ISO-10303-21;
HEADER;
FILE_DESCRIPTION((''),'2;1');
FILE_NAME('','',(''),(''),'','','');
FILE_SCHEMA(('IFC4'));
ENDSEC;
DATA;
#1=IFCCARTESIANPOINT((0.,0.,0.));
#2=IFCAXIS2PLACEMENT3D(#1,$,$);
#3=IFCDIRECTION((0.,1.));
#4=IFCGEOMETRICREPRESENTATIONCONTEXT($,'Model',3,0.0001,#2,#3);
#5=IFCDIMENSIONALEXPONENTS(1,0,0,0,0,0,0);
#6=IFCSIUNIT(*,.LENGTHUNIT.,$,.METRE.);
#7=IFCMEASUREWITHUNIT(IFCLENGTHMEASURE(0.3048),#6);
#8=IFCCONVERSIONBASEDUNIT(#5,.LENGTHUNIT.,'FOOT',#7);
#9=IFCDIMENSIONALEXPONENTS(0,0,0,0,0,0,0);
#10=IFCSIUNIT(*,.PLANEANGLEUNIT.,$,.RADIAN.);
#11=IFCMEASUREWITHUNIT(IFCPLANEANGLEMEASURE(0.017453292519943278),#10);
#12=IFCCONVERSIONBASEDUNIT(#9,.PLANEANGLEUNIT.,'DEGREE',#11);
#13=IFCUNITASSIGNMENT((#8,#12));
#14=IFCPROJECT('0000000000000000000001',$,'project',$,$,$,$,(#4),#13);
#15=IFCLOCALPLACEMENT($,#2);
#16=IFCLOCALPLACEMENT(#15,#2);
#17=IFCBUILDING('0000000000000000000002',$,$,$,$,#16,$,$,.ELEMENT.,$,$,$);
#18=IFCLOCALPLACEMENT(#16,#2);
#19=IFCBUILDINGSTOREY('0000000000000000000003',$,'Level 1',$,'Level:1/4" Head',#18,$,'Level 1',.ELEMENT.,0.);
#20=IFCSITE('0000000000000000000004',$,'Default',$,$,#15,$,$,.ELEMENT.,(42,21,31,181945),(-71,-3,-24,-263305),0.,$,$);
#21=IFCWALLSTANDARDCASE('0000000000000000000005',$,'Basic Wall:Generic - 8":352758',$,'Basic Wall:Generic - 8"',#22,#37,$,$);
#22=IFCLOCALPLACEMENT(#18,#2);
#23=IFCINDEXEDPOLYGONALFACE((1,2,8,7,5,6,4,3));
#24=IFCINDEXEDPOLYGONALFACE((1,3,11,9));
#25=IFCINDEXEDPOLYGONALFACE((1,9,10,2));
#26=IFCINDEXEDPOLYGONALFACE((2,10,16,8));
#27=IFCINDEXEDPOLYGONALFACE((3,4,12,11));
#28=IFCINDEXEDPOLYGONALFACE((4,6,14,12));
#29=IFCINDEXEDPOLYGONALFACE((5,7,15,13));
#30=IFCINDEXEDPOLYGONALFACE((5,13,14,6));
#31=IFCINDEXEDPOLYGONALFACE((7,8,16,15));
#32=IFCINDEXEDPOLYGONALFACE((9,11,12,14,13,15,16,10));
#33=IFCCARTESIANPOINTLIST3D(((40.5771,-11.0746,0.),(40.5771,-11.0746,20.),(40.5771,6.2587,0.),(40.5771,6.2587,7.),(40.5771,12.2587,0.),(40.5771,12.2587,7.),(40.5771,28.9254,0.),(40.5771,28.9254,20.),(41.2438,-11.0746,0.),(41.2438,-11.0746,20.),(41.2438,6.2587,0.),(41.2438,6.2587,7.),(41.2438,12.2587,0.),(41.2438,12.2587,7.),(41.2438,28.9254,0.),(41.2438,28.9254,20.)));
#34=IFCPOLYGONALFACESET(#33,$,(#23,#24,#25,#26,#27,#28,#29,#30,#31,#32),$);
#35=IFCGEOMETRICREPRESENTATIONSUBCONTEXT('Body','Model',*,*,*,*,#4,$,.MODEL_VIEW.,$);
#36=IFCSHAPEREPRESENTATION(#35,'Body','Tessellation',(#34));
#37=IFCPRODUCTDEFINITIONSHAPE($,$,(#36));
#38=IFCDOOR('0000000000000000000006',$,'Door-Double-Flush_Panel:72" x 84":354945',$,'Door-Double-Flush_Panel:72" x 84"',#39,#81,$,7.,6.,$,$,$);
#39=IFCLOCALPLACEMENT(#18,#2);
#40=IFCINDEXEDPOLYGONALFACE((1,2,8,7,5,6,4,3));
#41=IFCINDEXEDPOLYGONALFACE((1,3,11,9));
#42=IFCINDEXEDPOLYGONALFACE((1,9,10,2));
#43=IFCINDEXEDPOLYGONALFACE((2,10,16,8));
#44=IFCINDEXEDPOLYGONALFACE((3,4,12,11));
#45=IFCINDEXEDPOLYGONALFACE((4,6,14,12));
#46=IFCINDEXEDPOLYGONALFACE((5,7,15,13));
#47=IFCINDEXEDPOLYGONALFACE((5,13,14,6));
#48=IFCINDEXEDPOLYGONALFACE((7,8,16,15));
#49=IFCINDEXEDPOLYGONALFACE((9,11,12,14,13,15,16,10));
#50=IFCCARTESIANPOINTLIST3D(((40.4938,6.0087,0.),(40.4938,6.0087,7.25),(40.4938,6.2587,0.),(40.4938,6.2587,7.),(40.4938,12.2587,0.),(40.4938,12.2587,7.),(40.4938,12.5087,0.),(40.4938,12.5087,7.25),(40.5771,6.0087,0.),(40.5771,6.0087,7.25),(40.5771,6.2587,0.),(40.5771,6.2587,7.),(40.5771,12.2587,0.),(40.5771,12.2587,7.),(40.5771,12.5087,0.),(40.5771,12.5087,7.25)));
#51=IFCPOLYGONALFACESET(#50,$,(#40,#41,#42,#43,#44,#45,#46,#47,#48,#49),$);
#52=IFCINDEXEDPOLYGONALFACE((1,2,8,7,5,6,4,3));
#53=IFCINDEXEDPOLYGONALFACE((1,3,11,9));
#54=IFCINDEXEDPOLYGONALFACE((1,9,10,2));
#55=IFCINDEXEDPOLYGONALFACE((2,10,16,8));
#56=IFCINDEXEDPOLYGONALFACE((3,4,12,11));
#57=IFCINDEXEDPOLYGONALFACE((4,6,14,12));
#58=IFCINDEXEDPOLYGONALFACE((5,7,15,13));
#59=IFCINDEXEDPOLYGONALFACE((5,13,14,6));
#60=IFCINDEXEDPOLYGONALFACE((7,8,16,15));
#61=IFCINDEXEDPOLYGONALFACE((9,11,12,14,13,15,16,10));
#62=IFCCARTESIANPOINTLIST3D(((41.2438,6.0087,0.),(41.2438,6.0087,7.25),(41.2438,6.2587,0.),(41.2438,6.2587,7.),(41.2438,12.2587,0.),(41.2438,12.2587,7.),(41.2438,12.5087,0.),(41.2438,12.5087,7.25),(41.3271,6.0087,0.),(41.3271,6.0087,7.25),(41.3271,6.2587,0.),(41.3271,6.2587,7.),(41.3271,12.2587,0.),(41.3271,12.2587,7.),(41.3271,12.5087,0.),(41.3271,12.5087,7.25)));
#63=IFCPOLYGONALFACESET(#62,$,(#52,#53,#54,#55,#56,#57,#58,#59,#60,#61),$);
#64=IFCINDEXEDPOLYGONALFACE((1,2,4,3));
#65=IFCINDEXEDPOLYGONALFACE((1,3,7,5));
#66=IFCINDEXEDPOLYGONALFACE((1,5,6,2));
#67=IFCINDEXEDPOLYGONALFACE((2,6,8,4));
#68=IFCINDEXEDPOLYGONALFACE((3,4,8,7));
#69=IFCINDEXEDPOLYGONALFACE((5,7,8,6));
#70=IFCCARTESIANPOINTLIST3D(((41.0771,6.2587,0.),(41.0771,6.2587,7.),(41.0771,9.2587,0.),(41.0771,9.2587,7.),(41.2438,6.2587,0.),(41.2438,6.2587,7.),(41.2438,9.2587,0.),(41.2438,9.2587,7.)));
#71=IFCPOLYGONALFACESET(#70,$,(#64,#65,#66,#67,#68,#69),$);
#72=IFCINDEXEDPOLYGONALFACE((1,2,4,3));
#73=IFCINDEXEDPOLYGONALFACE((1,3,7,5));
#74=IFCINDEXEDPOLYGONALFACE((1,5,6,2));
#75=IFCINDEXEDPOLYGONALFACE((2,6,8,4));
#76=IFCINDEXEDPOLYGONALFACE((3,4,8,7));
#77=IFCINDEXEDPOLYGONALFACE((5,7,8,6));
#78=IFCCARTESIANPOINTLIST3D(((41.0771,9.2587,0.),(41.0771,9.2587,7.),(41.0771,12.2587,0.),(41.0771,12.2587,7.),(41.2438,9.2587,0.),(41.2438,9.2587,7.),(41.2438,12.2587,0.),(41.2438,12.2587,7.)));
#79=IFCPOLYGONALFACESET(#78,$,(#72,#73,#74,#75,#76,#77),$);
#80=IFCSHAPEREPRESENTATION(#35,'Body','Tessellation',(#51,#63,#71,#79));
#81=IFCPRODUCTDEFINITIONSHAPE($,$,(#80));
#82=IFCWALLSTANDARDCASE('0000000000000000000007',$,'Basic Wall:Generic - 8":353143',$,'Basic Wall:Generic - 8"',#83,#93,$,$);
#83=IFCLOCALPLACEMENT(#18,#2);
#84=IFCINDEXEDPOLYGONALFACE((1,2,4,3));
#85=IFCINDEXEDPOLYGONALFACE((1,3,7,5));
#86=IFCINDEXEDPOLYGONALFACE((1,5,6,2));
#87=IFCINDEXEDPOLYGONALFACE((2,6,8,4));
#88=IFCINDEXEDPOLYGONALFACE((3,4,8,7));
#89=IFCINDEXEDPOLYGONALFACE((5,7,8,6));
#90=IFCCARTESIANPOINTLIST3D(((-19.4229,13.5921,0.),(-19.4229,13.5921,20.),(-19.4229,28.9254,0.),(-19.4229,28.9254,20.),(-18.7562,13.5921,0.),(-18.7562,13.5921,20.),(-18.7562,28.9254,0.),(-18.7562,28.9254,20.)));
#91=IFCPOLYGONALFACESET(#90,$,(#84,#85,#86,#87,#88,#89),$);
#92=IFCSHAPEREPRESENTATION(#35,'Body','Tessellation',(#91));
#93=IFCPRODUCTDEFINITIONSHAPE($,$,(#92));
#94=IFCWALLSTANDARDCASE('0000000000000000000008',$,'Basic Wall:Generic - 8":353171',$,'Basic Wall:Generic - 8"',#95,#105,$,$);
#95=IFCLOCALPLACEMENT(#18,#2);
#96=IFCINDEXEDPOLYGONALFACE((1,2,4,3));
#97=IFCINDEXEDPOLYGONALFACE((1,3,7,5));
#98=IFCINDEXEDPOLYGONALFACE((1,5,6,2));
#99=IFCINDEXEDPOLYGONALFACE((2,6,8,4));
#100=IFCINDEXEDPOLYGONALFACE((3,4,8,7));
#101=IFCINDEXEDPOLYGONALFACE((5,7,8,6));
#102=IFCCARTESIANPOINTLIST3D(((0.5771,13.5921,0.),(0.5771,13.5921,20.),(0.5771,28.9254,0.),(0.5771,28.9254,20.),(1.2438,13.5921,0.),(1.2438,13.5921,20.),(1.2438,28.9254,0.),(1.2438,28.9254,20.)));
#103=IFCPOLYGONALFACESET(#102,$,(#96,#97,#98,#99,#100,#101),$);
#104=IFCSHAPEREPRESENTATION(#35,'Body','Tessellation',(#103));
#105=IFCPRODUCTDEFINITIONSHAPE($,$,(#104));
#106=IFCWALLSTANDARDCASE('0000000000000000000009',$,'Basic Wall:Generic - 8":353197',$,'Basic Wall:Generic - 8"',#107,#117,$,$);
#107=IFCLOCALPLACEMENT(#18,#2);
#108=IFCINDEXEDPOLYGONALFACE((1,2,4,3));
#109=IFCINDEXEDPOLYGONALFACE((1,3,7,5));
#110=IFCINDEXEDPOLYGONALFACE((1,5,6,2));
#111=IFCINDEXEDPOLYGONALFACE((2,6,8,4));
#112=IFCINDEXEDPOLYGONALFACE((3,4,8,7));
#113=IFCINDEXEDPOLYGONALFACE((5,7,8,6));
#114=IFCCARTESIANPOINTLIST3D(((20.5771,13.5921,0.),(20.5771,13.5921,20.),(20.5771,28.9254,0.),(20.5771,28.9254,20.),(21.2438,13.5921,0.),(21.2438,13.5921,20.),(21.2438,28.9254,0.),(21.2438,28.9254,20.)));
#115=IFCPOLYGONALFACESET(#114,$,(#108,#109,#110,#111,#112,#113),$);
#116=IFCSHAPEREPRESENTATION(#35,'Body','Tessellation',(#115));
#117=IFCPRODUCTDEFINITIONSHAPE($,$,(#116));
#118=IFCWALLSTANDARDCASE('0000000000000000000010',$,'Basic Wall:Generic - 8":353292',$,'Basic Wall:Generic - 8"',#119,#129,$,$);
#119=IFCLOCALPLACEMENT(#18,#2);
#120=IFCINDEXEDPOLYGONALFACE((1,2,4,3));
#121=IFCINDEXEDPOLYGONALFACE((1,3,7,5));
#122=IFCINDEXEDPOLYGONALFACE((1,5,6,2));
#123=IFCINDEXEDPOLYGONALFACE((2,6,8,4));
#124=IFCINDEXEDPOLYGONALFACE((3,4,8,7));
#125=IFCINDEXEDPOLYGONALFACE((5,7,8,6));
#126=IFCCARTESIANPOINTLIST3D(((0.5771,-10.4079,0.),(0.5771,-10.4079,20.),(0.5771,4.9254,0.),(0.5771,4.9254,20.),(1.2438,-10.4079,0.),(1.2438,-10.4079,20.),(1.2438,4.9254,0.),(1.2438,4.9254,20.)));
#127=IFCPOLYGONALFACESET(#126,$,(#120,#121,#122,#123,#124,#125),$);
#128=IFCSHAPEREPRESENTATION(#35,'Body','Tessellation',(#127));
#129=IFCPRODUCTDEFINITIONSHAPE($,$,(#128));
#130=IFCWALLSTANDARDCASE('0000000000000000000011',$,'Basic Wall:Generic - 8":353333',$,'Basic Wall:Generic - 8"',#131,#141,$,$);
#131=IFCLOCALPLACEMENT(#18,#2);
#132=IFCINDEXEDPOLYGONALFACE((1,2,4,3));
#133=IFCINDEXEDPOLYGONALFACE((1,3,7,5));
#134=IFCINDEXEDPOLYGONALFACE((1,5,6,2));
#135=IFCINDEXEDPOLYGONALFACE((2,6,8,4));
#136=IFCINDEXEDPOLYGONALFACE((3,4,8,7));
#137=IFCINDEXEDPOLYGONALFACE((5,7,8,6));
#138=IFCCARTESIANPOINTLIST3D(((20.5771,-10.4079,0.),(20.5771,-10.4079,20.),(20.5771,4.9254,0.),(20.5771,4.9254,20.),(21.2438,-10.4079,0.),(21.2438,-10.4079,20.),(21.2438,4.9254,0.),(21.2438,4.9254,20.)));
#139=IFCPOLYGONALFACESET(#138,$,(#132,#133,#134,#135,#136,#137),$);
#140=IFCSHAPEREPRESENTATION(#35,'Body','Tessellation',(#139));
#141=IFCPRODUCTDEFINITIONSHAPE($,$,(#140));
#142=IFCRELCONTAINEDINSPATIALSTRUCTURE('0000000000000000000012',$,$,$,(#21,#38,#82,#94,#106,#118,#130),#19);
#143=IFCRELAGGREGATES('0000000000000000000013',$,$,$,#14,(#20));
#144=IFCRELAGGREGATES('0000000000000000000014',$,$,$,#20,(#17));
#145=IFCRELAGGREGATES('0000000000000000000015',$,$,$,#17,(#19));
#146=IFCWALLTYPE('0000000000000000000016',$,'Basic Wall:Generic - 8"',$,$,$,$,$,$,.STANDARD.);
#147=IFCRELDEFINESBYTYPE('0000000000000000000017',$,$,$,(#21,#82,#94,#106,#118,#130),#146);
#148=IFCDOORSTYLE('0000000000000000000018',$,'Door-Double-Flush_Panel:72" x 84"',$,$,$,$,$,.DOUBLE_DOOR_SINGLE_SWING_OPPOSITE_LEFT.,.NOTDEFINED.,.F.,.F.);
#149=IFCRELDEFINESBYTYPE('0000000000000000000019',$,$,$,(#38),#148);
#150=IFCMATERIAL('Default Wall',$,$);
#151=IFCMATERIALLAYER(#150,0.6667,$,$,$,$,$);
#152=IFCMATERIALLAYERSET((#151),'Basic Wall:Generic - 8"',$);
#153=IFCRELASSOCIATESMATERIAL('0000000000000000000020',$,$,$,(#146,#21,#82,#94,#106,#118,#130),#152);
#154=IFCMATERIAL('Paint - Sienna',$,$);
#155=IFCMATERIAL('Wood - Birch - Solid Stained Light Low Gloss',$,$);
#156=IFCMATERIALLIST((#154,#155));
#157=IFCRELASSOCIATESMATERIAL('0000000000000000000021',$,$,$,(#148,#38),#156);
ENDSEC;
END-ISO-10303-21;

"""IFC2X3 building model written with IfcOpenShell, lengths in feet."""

from ifc_helpers import new_model, entity, si_unit, converted_unit, direction, frame, frame_2d, origin, place, context, subcontext, project, spatial, polyline, rectangle, outline, extrude, source, transform, mapped, material, material_list, layer, layer_set, layer_usage, type_object, type_shapes, element, fill, save


model = new_model("IFC2X3")

# Units and contexts
model_context = context("Model", 3, precision=0.0001, world=origin(), true_north=direction((0.0, 1.0)))
body_context = subcontext(model_context, "Body", "Model", "MODEL_VIEW")
ifc_project = project(units=[converted_unit("LENGTHUNIT", "FOOT", entity("IfcLengthMeasure", 0.3048), si_unit("LENGTHUNIT", "METRE"), dimensions=[1, 0, 0, 0, 0, 0, 0]), converted_unit("PLANEANGLEUNIT", "DEGREE", entity("IfcPlaneAngleMeasure", 0.017453292519943278), si_unit("PLANEANGLEUNIT", "RADIAN"), dimensions=[0, 0, 0, 0, 0, 0, 0])], contexts=[model_context])

# Site, building, storey
site_placement = place(None, origin())
site = spatial("IfcSite", under=ifc_project, at=site_placement, Name="Default", CompositionType="ELEMENT", RefLatitude=(42, 21, 31, 181945), RefLongitude=(-71, -3, -24, -263305), RefElevation=0.0)
building_placement = place(site_placement, origin())
building = spatial("IfcBuilding", under=site, at=building_placement, CompositionType="ELEMENT")
storey_placement = place(building_placement, origin())
storey = spatial("IfcBuildingStorey", under=building, at=storey_placement, Name="Level 1", ObjectType="Level:1/4\" Head", LongName="Level 1", CompositionType="ELEMENT", Elevation=0.0)

# Wall, opening, door
ifc_material_1 = material(Name="Default Wall")
ifc_layer = layer(ifc_material_1, 0.6667)
ifc_layer_set = layer_set([ifc_layer], Name="Basic Wall:Generic - 8\"")
ifc_layer_usage = layer_usage(ifc_layer_set, "AXIS2", "NEGATIVE", 0.3333)
wall_type = type_object("IfcWallType", Name="Basic Wall:Generic - 8\"", PredefinedType="STANDARD", material=ifc_layer_set)
wall_1_placement = place(storey_placement, frame((40.9105, 28.9254, 0.0), z_axis=(0.0, 0.0, 1.0), x_axis=(0.0, -1.0, 0.0)))
wall_1 = element("IfcWallStandardCase", 1, at=wall_1_placement, inside=storey, type_object=wall_type, material=ifc_layer_usage, Name="Basic Wall:Generic - 8\":352758", ObjectType="Basic Wall:Generic - 8\"", context=body_context, shape_type="SweptSolid", body=[
    extrude(rectangle(XDim=40.0, YDim=0.6667, at=frame_2d((20.0, 0.0), x_axis=(-1.0, 0.0))), origin(), (0.0, 0.0, 1.0), 20.0),
])
opening_1_placement = place(wall_1_placement, frame((16.6667, -0.3333, 0.0)))
opening_1 = element("IfcOpeningElement", 2, at=opening_1_placement, cuts=wall_1, ObjectType="Opening", context=body_context, shape_type="SweptSolid", body=[
    extrude(rectangle(XDim=7.0, YDim=6.0, at=frame_2d((3.5, 3.0), x_axis=(1.0, 0.0))), frame((0.0, 0.0, 0.0), z_axis=(0.0, 1.0, 0.0), x_axis=(0.0, 0.0, 1.0)), (0.0, 0.0, 1.0), 0.6667),
])
ifc_material_2 = material(Name="Paint - Sienna")
ifc_material_3 = material(Name="Wood - Birch - Solid Stained Light Low Gloss")
ifc_material_list_1 = material_list([ifc_material_2, ifc_material_3])
door_style = type_object("IfcDoorStyle", Name="Door-Double-Flush_Panel:72\" x 84\"", ConstructionType="NOTDEFINED", OperationType="DOUBLE_DOOR_SINGLE_SWING_OPPOSITE_LEFT", ParameterTakesPrecedence=False, Sizeable=False, material=ifc_material_list_1)
shared_shape_1 = source(origin(), body_context, "Body", "SweptSolid", [
    extrude(outline(polyline([(-3.4375, 3.0), (3.5625, 3.0), (3.5625, 3.25), (-3.6875, 3.25), (-3.6875, -3.25), (3.5625, -3.25), (3.5625, -3.0), (-3.4375, -3.0), (-3.4375, 3.0)])), frame((3.0, -0.0833, 3.5625), z_axis=(0.0, 1.0, 0.0), x_axis=(0.0, 0.0, -1.0)), (0.0, 0.0, 1.0), 0.0833),
    extrude(outline(polyline([(-3.4375, 3.0), (3.5625, 3.0), (3.5625, 3.25), (-3.6875, 3.25), (-3.6875, -3.25), (3.5625, -3.25), (3.5625, -3.0), (-3.4375, -3.0), (-3.4375, 3.0)])), frame((3.0, 0.6667, 3.5625), z_axis=(0.0, 1.0, 0.0), x_axis=(0.0, 0.0, -1.0)), (0.0, 0.0, 1.0), 0.0833),
    extrude(rectangle(XDim=0.1667, YDim=3.0, at=frame_2d((0.0, 0.0), x_axis=(1.0, 0.0))), frame((4.5, 0.5833, 0.0), z_axis=(0.0, 0.0, 1.0), x_axis=(0.0, -1.0, 0.0)), (0.0, 0.0, 1.0), 7.0),
    extrude(rectangle(XDim=0.1667, YDim=3.0, at=frame_2d((0.0, 0.0), x_axis=(1.0, 0.0))), frame((1.5, 0.5833, 0.0), z_axis=(0.0, 0.0, 1.0), x_axis=(0.0, -1.0, 0.0)), (0.0, 0.0, 1.0), 7.0),
])
type_shapes(door_style, [shared_shape_1])
door_placement = place(opening_1_placement, origin())
door = element("IfcDoor", 3, at=door_placement, inside=storey, type_object=door_style, material=ifc_material_list_1, Name="Door-Double-Flush_Panel:72\" x 84\":354945", ObjectType="Door-Double-Flush_Panel:72\" x 84\"", OverallHeight=7.0, OverallWidth=6.0, context=body_context, shape_type="MappedRepresentation", body=[
    mapped(shared_shape_1, transform((0.0, 0.0, 0.0), scale=1.0)),
])
fill(opening_1, door)

# Walls
wall_2_placement = place(storey_placement, frame((-19.0895, 28.9254, 0.0), z_axis=(0.0, 0.0, 1.0), x_axis=(0.0, -1.0, 0.0)))
element("IfcWallStandardCase", 4, at=wall_2_placement, inside=storey, type_object=wall_type, material=ifc_layer_usage, Name="Basic Wall:Generic - 8\":353143", ObjectType="Basic Wall:Generic - 8\"", context=body_context, shape_type="SweptSolid", body=[
    extrude(rectangle(XDim=15.3333, YDim=0.6667, at=frame_2d((7.6667, 0.0), x_axis=(-1.0, 0.0))), origin(), (0.0, 0.0, 1.0), 20.0),
])
wall_3_placement = place(storey_placement, frame((0.9105, 28.9254, 0.0), z_axis=(0.0, 0.0, 1.0), x_axis=(0.0, -1.0, 0.0)))
element("IfcWallStandardCase", 5, at=wall_3_placement, inside=storey, type_object=wall_type, material=ifc_layer_usage, Name="Basic Wall:Generic - 8\":353171", ObjectType="Basic Wall:Generic - 8\"", context=body_context, shape_type="SweptSolid", body=[
    extrude(rectangle(XDim=15.3333, YDim=0.6667, at=frame_2d((7.6667, 0.0), x_axis=(-1.0, 0.0))), origin(), (0.0, 0.0, 1.0), 20.0),
])
wall_4_placement = place(storey_placement, frame((20.9105, 28.9254, 0.0), z_axis=(0.0, 0.0, 1.0), x_axis=(0.0, -1.0, 0.0)))
element("IfcWallStandardCase", 6, at=wall_4_placement, inside=storey, type_object=wall_type, material=ifc_layer_usage, Name="Basic Wall:Generic - 8\":353197", ObjectType="Basic Wall:Generic - 8\"", context=body_context, shape_type="SweptSolid", body=[
    extrude(rectangle(XDim=15.3333, YDim=0.6667, at=frame_2d((7.6667, 0.0), x_axis=(-1.0, 0.0))), origin(), (0.0, 0.0, 1.0), 20.0),
])
wall_5_placement = place(storey_placement, frame((0.9105, 4.9254, 0.0), z_axis=(0.0, 0.0, 1.0), x_axis=(0.0, -1.0, 0.0)))
element("IfcWallStandardCase", 7, at=wall_5_placement, inside=storey, type_object=wall_type, material=ifc_layer_usage, Name="Basic Wall:Generic - 8\":353292", ObjectType="Basic Wall:Generic - 8\"", context=body_context, shape_type="SweptSolid", body=[
    extrude(rectangle(XDim=15.3333, YDim=0.6667, at=frame_2d((7.6667, 0.0), x_axis=(-1.0, 0.0))), origin(), (0.0, 0.0, 1.0), 20.0),
])
wall_6_placement = place(storey_placement, frame((20.9105, 4.9254, 0.0), z_axis=(0.0, 0.0, 1.0), x_axis=(0.0, -1.0, 0.0)))
element("IfcWallStandardCase", 8, at=wall_6_placement, inside=storey, type_object=wall_type, material=ifc_layer_usage, Name="Basic Wall:Generic - 8\":353333", ObjectType="Basic Wall:Generic - 8\"", context=body_context, shape_type="SweptSolid", body=[
    extrude(rectangle(XDim=15.3333, YDim=0.6667, at=frame_2d((7.6667, 0.0), x_axis=(-1.0, 0.0))), origin(), (0.0, 0.0, 1.0), 20.0),
])

save(model, "model.ifc")
